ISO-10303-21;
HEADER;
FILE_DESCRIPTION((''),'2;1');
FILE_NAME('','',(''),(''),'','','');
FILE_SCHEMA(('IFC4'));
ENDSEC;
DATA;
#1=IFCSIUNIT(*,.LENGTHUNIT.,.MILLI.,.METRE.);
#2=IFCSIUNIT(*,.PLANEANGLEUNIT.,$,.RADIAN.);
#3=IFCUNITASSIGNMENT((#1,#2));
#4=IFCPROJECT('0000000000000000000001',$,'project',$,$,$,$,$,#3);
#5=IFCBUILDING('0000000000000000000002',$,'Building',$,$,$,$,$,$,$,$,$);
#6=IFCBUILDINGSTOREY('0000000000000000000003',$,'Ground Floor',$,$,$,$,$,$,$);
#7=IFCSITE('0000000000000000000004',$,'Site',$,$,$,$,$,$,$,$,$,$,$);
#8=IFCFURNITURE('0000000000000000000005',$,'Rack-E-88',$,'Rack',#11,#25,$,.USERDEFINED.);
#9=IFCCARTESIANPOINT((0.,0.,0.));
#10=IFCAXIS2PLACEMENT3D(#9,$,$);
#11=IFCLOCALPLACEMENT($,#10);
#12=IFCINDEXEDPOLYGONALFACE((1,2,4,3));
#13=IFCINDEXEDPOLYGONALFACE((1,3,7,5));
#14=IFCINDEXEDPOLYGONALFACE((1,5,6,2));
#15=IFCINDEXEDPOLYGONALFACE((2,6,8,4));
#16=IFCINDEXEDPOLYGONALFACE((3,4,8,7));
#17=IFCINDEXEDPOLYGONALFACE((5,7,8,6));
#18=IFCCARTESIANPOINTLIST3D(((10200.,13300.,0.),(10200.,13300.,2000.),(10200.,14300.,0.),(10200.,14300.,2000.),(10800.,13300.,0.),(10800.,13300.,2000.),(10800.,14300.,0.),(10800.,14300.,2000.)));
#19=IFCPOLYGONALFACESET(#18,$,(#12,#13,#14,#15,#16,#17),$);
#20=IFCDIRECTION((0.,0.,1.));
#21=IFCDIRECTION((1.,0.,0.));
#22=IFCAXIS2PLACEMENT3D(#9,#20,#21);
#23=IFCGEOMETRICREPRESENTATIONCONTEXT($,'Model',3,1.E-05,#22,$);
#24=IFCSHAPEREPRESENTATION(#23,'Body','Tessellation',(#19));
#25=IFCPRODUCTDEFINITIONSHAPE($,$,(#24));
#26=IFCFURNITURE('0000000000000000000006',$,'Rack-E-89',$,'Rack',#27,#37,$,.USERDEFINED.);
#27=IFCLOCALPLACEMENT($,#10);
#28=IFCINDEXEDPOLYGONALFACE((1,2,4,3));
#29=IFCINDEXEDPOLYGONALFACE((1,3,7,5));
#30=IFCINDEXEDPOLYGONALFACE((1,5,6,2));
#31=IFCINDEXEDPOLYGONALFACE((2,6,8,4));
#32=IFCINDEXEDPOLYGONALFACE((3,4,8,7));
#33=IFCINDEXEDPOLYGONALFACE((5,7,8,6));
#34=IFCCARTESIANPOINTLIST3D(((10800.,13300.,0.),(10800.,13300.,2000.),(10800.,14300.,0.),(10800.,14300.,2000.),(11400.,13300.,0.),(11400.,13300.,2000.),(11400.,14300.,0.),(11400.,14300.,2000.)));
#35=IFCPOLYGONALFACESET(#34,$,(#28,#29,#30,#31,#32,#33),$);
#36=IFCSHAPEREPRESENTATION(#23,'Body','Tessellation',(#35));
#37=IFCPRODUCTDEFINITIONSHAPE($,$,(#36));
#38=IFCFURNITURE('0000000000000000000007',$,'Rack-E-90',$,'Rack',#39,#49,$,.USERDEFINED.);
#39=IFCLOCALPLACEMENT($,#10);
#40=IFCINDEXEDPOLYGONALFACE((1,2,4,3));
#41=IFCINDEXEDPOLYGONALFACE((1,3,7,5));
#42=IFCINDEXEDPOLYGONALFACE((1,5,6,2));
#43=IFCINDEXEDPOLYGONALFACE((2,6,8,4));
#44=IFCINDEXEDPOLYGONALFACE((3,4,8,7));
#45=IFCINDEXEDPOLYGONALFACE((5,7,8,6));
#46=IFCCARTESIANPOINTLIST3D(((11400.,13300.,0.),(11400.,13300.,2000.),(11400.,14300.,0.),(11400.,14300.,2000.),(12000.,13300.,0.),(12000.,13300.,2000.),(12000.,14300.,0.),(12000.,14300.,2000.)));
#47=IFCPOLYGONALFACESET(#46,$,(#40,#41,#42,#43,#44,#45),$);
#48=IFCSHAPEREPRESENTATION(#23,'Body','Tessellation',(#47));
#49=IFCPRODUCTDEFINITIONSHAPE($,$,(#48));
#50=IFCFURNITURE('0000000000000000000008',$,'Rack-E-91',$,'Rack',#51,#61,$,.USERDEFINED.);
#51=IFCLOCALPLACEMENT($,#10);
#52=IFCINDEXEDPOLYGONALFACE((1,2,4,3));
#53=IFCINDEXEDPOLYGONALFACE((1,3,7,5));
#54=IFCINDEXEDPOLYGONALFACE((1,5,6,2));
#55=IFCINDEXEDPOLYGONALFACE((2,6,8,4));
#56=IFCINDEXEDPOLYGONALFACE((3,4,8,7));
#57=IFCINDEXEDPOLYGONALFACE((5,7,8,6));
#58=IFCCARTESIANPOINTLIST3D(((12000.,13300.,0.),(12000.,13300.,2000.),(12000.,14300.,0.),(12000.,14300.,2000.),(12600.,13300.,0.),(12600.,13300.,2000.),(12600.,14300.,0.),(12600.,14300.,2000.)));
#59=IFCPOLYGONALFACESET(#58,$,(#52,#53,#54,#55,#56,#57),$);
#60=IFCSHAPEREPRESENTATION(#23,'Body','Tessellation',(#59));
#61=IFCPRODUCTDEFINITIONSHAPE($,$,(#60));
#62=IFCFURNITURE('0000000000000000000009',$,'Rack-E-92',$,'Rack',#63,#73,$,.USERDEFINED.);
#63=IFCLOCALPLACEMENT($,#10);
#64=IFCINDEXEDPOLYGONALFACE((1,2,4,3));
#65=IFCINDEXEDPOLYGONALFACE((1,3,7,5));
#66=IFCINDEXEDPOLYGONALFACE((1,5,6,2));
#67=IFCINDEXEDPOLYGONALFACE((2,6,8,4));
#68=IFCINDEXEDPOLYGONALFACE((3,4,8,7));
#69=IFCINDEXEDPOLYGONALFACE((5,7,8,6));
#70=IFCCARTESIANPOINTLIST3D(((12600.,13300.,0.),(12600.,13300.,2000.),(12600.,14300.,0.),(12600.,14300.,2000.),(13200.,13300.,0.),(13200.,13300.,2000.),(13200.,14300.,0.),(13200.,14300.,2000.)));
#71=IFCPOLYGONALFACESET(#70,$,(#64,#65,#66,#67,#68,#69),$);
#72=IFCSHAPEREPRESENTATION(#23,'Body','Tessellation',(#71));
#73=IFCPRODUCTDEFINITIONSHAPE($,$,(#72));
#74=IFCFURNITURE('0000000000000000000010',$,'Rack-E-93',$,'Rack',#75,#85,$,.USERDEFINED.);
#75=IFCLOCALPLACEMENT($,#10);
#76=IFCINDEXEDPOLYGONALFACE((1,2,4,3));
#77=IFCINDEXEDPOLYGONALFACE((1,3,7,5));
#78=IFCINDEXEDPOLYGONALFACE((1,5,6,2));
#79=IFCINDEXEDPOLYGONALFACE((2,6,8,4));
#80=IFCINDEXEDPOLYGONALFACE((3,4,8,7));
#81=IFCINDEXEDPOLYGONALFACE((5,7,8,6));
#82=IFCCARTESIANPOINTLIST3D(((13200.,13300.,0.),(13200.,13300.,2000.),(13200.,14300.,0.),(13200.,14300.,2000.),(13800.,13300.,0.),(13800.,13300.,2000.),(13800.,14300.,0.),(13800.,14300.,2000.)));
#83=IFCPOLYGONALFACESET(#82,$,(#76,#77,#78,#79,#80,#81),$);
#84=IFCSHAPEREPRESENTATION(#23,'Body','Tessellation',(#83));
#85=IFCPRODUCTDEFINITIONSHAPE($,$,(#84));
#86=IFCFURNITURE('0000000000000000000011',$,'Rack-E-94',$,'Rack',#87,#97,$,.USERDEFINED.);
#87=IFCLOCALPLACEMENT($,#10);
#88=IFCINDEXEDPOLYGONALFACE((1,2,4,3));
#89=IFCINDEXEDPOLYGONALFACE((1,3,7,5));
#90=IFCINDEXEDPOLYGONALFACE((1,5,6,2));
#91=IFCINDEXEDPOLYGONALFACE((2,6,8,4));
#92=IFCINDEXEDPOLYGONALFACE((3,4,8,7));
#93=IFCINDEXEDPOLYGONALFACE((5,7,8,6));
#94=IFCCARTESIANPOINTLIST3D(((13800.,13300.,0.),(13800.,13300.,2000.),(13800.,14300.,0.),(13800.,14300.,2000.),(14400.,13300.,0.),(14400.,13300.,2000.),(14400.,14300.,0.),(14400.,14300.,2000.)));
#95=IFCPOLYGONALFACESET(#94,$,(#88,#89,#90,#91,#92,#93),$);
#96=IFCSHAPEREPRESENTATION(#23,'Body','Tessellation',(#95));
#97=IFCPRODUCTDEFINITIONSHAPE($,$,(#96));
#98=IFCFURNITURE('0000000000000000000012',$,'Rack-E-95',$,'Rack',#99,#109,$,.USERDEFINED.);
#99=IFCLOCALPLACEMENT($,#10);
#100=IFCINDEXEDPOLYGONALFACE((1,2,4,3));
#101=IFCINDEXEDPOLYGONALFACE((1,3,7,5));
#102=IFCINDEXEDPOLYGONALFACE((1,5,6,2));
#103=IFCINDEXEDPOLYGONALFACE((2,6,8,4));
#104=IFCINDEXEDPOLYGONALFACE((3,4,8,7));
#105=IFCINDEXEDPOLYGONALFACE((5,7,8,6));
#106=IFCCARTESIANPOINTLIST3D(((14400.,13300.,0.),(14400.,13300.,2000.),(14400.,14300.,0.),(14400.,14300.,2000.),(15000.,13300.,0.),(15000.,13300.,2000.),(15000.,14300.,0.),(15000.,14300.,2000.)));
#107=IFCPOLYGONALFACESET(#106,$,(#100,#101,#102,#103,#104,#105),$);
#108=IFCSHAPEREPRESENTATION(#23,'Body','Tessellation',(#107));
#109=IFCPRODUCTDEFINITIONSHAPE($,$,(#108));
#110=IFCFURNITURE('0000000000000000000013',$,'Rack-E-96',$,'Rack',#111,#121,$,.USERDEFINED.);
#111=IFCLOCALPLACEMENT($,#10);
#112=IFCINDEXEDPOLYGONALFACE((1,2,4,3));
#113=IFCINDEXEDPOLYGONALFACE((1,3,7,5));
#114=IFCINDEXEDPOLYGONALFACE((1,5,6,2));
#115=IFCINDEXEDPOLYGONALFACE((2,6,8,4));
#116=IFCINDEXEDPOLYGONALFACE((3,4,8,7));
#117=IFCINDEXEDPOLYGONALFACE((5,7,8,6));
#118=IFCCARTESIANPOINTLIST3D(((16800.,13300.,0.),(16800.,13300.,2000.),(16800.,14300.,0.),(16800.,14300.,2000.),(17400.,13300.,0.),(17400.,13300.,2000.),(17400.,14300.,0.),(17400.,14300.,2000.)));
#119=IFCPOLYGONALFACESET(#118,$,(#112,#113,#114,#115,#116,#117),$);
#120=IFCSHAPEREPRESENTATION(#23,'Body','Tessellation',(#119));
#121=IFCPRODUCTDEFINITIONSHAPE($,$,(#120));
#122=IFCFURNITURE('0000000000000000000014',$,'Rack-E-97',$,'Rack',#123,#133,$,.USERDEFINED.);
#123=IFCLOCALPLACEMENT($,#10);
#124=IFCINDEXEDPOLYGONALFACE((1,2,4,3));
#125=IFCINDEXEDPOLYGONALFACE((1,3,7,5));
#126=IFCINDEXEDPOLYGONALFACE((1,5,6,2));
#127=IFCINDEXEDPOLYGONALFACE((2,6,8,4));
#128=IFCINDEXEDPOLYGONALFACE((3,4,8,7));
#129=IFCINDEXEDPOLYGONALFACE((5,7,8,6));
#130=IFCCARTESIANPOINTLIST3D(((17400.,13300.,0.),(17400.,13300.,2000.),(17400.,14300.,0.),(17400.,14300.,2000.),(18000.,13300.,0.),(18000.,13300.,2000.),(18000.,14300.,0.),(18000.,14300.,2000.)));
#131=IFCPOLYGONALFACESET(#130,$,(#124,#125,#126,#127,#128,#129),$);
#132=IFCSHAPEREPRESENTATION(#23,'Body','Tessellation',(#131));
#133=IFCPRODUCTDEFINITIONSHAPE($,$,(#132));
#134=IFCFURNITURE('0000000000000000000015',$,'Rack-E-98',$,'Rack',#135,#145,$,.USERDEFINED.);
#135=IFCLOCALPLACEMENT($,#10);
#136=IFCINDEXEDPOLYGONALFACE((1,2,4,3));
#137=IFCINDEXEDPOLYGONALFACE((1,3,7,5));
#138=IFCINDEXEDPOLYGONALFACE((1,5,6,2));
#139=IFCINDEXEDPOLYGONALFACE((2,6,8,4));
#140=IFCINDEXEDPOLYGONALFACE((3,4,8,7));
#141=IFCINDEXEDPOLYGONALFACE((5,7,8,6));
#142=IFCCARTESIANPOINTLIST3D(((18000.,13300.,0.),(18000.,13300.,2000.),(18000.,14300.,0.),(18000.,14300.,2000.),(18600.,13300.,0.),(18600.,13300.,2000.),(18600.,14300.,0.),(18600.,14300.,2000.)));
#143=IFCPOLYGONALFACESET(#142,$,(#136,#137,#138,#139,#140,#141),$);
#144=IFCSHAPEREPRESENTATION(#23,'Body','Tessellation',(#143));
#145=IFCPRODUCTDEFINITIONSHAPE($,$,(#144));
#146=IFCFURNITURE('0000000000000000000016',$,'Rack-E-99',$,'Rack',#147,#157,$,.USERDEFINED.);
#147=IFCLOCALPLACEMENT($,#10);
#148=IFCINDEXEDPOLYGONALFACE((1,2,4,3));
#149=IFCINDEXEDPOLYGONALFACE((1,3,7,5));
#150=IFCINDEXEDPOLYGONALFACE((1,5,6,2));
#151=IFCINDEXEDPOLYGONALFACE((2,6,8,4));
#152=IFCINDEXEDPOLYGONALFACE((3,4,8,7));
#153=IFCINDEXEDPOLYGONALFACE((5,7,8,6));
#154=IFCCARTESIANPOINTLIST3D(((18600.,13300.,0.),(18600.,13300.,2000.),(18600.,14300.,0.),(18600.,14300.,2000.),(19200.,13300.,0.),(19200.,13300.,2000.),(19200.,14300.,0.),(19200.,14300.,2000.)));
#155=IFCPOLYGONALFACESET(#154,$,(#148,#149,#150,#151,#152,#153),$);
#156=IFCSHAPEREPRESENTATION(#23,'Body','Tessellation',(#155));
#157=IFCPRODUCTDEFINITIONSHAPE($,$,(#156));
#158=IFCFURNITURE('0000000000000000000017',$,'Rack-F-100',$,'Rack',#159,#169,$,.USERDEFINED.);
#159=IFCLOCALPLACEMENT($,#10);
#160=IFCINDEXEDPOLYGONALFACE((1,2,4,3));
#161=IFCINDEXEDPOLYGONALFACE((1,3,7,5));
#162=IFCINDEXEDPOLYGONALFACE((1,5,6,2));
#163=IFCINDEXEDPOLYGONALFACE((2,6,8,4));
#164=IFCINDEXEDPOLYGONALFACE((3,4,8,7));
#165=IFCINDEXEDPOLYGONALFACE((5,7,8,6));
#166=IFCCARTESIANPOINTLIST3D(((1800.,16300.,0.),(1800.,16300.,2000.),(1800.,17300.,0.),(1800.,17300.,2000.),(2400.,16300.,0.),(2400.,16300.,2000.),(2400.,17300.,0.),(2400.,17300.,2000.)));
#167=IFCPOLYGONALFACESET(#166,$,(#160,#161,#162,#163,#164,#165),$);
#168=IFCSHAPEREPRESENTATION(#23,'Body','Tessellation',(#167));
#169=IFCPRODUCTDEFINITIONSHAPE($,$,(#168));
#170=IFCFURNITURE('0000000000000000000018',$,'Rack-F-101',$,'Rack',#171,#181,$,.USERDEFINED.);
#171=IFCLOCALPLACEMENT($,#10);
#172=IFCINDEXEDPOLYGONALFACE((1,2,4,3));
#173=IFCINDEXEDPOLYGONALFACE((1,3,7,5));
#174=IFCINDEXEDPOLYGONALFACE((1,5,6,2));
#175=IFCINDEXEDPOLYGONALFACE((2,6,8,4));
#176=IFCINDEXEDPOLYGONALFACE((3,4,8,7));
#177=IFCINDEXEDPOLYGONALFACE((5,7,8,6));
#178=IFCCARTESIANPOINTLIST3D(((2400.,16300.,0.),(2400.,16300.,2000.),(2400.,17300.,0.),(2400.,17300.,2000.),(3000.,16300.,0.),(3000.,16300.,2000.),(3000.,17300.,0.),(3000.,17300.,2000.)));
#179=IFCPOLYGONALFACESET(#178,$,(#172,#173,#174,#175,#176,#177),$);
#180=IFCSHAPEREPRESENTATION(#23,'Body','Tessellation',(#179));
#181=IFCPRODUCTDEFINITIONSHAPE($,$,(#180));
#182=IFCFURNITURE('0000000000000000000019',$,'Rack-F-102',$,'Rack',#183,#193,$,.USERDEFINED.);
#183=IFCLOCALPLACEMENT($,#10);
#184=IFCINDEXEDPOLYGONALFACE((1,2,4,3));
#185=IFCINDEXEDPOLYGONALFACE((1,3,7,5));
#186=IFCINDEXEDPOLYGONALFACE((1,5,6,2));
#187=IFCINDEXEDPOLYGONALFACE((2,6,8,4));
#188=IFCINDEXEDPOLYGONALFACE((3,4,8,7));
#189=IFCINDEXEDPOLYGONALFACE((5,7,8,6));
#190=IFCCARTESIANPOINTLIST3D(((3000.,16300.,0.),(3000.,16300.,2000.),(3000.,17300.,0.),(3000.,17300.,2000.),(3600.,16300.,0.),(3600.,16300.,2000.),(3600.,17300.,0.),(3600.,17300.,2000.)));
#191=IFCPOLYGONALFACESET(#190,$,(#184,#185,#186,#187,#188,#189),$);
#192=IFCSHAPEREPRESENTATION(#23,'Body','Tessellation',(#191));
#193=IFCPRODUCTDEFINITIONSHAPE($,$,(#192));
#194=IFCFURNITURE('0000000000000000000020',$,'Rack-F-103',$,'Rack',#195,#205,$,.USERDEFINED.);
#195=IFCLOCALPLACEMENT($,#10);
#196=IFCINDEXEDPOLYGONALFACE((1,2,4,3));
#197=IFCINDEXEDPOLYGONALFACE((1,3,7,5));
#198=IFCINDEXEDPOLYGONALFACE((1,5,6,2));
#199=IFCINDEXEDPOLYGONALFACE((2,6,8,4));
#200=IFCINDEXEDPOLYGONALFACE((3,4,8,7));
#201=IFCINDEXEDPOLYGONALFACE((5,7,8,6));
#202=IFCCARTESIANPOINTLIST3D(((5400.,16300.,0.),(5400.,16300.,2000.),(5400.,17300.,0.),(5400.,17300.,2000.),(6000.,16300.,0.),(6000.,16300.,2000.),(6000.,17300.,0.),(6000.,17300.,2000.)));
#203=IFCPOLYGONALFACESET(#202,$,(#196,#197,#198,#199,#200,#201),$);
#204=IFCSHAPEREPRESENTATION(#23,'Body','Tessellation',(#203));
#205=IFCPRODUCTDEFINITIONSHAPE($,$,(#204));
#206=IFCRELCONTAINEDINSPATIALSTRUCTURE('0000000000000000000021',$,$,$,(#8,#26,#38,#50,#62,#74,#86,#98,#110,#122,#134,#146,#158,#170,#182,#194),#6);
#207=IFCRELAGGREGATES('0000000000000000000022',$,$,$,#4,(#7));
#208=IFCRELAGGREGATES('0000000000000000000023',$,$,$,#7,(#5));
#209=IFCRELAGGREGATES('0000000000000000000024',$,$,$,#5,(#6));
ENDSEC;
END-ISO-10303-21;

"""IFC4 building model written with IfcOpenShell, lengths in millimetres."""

from ifc_helpers import new_model, si_unit, frame, origin_with_axes, place, context, project, spatial, rectangle, extrude, element, save


model = new_model("IFC4")

# Units and contexts
model_context = context("Model", 3, precision=1e-05, world=origin_with_axes())
ifc_project = project(units=[si_unit("LENGTHUNIT", "METRE", prefix="MILLI"), si_unit("PLANEANGLEUNIT", "RADIAN")])

# Site, building, storey
site = spatial("IfcSite", under=ifc_project, Name="Site")
building = spatial("IfcBuilding", under=site, Name="Building")
storey = spatial("IfcBuildingStorey", under=building, Name="Ground Floor")

# Furniture
furniture_1_placement = place(None, origin_with_axes())
element("IfcFurniture", 1, at=furniture_1_placement, inside=storey, Name="Rack-E-88", ObjectType="Rack", PredefinedType="USERDEFINED", context=model_context, shape_type="SweptSolid", body=[
    extrude(rectangle(XDim=600.0, YDim=1000.0), frame((10500.0, 13800.0, 0.0), z_axis=(0.0, 0.0, 1.0), x_axis=(1.0, 0.0, 0.0)), (0.0, 0.0, 1.0), 2000.0),
])
furniture_2_placement = place(None, origin_with_axes())
element("IfcFurniture", 2, at=furniture_2_placement, inside=storey, Name="Rack-E-89", ObjectType="Rack", PredefinedType="USERDEFINED", context=model_context, shape_type="SweptSolid", body=[
    extrude(rectangle(XDim=600.0, YDim=1000.0), frame((11100.0, 13800.0, 0.0), z_axis=(0.0, 0.0, 1.0), x_axis=(1.0, 0.0, 0.0)), (0.0, 0.0, 1.0), 2000.0),
])
furniture_3_placement = place(None, origin_with_axes())
element("IfcFurniture", 3, at=furniture_3_placement, inside=storey, Name="Rack-E-90", ObjectType="Rack", PredefinedType="USERDEFINED", context=model_context, shape_type="SweptSolid", body=[
    extrude(rectangle(XDim=600.0, YDim=1000.0), frame((11700.0, 13800.0, 0.0), z_axis=(0.0, 0.0, 1.0), x_axis=(1.0, 0.0, 0.0)), (0.0, 0.0, 1.0), 2000.0),
])
furniture_4_placement = place(None, origin_with_axes())
element("IfcFurniture", 4, at=furniture_4_placement, inside=storey, Name="Rack-E-91", ObjectType="Rack", PredefinedType="USERDEFINED", context=model_context, shape_type="SweptSolid", body=[
    extrude(rectangle(XDim=600.0, YDim=1000.0), frame((12300.0, 13800.0, 0.0), z_axis=(0.0, 0.0, 1.0), x_axis=(1.0, 0.0, 0.0)), (0.0, 0.0, 1.0), 2000.0),
])
furniture_5_placement = place(None, origin_with_axes())
element("IfcFurniture", 5, at=furniture_5_placement, inside=storey, Name="Rack-E-92", ObjectType="Rack", PredefinedType="USERDEFINED", context=model_context, shape_type="SweptSolid", body=[
    extrude(rectangle(XDim=600.0, YDim=1000.0), frame((12900.0, 13800.0, 0.0), z_axis=(0.0, 0.0, 1.0), x_axis=(1.0, 0.0, 0.0)), (0.0, 0.0, 1.0), 2000.0),
])
furniture_6_placement = place(None, origin_with_axes())
element("IfcFurniture", 6, at=furniture_6_placement, inside=storey, Name="Rack-E-93", ObjectType="Rack", PredefinedType="USERDEFINED", context=model_context, shape_type="SweptSolid", body=[
    extrude(rectangle(XDim=600.0, YDim=1000.0), frame((13500.0, 13800.0, 0.0), z_axis=(0.0, 0.0, 1.0), x_axis=(1.0, 0.0, 0.0)), (0.0, 0.0, 1.0), 2000.0),
])
furniture_7_placement = place(None, origin_with_axes())
element("IfcFurniture", 7, at=furniture_7_placement, inside=storey, Name="Rack-E-94", ObjectType="Rack", PredefinedType="USERDEFINED", context=model_context, shape_type="SweptSolid", body=[
    extrude(rectangle(XDim=600.0, YDim=1000.0), frame((14100.0, 13800.0, 0.0), z_axis=(0.0, 0.0, 1.0), x_axis=(1.0, 0.0, 0.0)), (0.0, 0.0, 1.0), 2000.0),
])
furniture_8_placement = place(None, origin_with_axes())
element("IfcFurniture", 8, at=furniture_8_placement, inside=storey, Name="Rack-E-95", ObjectType="Rack", PredefinedType="USERDEFINED", context=model_context, shape_type="SweptSolid", body=[
    extrude(rectangle(XDim=600.0, YDim=1000.0), frame((14700.0, 13800.0, 0.0), z_axis=(0.0, 0.0, 1.0), x_axis=(1.0, 0.0, 0.0)), (0.0, 0.0, 1.0), 2000.0),
])
furniture_9_placement = place(None, origin_with_axes())
element("IfcFurniture", 9, at=furniture_9_placement, inside=storey, Name="Rack-E-96", ObjectType="Rack", PredefinedType="USERDEFINED", context=model_context, shape_type="SweptSolid", body=[
    extrude(rectangle(XDim=600.0, YDim=1000.0), frame((17100.0, 13800.0, 0.0), z_axis=(0.0, 0.0, 1.0), x_axis=(1.0, 0.0, 0.0)), (0.0, 0.0, 1.0), 2000.0),
])
furniture_10_placement = place(None, origin_with_axes())
element("IfcFurniture", 10, at=furniture_10_placement, inside=storey, Name="Rack-E-97", ObjectType="Rack", PredefinedType="USERDEFINED", context=model_context, shape_type="SweptSolid", body=[
    extrude(rectangle(XDim=600.0, YDim=1000.0), frame((17700.0, 13800.0, 0.0), z_axis=(0.0, 0.0, 1.0), x_axis=(1.0, 0.0, 0.0)), (0.0, 0.0, 1.0), 2000.0),
])
furniture_11_placement = place(None, origin_with_axes())
element("IfcFurniture", 11, at=furniture_11_placement, inside=storey, Name="Rack-E-98", ObjectType="Rack", PredefinedType="USERDEFINED", context=model_context, shape_type="SweptSolid", body=[
    extrude(rectangle(XDim=600.0, YDim=1000.0), frame((18300.0, 13800.0, 0.0), z_axis=(0.0, 0.0, 1.0), x_axis=(1.0, 0.0, 0.0)), (0.0, 0.0, 1.0), 2000.0),
])
furniture_12_placement = place(None, origin_with_axes())
element("IfcFurniture", 12, at=furniture_12_placement, inside=storey, Name="Rack-E-99", ObjectType="Rack", PredefinedType="USERDEFINED", context=model_context, shape_type="SweptSolid", body=[
    extrude(rectangle(XDim=600.0, YDim=1000.0), frame((18900.0, 13800.0, 0.0), z_axis=(0.0, 0.0, 1.0), x_axis=(1.0, 0.0, 0.0)), (0.0, 0.0, 1.0), 2000.0),
])
furniture_13_placement = place(None, origin_with_axes())
element("IfcFurniture", 13, at=furniture_13_placement, inside=storey, Name="Rack-F-100", ObjectType="Rack", PredefinedType="USERDEFINED", context=model_context, shape_type="SweptSolid", body=[
    extrude(rectangle(XDim=600.0, YDim=1000.0), frame((2100.0, 16800.0, 0.0), z_axis=(0.0, 0.0, 1.0), x_axis=(1.0, 0.0, 0.0)), (0.0, 0.0, 1.0), 2000.0),
])
furniture_14_placement = place(None, origin_with_axes())
element("IfcFurniture", 14, at=furniture_14_placement, inside=storey, Name="Rack-F-101", ObjectType="Rack", PredefinedType="USERDEFINED", context=model_context, shape_type="SweptSolid", body=[
    extrude(rectangle(XDim=600.0, YDim=1000.0), frame((2700.0, 16800.0, 0.0), z_axis=(0.0, 0.0, 1.0), x_axis=(1.0, 0.0, 0.0)), (0.0, 0.0, 1.0), 2000.0),
])
furniture_15_placement = place(None, origin_with_axes())
element("IfcFurniture", 15, at=furniture_15_placement, inside=storey, Name="Rack-F-102", ObjectType="Rack", PredefinedType="USERDEFINED", context=model_context, shape_type="SweptSolid", body=[
    extrude(rectangle(XDim=600.0, YDim=1000.0), frame((3300.0, 16800.0, 0.0), z_axis=(0.0, 0.0, 1.0), x_axis=(1.0, 0.0, 0.0)), (0.0, 0.0, 1.0), 2000.0),
])
furniture_16_placement = place(None, origin_with_axes())
element("IfcFurniture", 16, at=furniture_16_placement, inside=storey, Name="Rack-F-103", ObjectType="Rack", PredefinedType="USERDEFINED", context=model_context, shape_type="SweptSolid", body=[
    extrude(rectangle(XDim=600.0, YDim=1000.0), frame((5700.0, 16800.0, 0.0), z_axis=(0.0, 0.0, 1.0), x_axis=(1.0, 0.0, 0.0)), (0.0, 0.0, 1.0), 2000.0),
])

save(model, "model.ifc")
